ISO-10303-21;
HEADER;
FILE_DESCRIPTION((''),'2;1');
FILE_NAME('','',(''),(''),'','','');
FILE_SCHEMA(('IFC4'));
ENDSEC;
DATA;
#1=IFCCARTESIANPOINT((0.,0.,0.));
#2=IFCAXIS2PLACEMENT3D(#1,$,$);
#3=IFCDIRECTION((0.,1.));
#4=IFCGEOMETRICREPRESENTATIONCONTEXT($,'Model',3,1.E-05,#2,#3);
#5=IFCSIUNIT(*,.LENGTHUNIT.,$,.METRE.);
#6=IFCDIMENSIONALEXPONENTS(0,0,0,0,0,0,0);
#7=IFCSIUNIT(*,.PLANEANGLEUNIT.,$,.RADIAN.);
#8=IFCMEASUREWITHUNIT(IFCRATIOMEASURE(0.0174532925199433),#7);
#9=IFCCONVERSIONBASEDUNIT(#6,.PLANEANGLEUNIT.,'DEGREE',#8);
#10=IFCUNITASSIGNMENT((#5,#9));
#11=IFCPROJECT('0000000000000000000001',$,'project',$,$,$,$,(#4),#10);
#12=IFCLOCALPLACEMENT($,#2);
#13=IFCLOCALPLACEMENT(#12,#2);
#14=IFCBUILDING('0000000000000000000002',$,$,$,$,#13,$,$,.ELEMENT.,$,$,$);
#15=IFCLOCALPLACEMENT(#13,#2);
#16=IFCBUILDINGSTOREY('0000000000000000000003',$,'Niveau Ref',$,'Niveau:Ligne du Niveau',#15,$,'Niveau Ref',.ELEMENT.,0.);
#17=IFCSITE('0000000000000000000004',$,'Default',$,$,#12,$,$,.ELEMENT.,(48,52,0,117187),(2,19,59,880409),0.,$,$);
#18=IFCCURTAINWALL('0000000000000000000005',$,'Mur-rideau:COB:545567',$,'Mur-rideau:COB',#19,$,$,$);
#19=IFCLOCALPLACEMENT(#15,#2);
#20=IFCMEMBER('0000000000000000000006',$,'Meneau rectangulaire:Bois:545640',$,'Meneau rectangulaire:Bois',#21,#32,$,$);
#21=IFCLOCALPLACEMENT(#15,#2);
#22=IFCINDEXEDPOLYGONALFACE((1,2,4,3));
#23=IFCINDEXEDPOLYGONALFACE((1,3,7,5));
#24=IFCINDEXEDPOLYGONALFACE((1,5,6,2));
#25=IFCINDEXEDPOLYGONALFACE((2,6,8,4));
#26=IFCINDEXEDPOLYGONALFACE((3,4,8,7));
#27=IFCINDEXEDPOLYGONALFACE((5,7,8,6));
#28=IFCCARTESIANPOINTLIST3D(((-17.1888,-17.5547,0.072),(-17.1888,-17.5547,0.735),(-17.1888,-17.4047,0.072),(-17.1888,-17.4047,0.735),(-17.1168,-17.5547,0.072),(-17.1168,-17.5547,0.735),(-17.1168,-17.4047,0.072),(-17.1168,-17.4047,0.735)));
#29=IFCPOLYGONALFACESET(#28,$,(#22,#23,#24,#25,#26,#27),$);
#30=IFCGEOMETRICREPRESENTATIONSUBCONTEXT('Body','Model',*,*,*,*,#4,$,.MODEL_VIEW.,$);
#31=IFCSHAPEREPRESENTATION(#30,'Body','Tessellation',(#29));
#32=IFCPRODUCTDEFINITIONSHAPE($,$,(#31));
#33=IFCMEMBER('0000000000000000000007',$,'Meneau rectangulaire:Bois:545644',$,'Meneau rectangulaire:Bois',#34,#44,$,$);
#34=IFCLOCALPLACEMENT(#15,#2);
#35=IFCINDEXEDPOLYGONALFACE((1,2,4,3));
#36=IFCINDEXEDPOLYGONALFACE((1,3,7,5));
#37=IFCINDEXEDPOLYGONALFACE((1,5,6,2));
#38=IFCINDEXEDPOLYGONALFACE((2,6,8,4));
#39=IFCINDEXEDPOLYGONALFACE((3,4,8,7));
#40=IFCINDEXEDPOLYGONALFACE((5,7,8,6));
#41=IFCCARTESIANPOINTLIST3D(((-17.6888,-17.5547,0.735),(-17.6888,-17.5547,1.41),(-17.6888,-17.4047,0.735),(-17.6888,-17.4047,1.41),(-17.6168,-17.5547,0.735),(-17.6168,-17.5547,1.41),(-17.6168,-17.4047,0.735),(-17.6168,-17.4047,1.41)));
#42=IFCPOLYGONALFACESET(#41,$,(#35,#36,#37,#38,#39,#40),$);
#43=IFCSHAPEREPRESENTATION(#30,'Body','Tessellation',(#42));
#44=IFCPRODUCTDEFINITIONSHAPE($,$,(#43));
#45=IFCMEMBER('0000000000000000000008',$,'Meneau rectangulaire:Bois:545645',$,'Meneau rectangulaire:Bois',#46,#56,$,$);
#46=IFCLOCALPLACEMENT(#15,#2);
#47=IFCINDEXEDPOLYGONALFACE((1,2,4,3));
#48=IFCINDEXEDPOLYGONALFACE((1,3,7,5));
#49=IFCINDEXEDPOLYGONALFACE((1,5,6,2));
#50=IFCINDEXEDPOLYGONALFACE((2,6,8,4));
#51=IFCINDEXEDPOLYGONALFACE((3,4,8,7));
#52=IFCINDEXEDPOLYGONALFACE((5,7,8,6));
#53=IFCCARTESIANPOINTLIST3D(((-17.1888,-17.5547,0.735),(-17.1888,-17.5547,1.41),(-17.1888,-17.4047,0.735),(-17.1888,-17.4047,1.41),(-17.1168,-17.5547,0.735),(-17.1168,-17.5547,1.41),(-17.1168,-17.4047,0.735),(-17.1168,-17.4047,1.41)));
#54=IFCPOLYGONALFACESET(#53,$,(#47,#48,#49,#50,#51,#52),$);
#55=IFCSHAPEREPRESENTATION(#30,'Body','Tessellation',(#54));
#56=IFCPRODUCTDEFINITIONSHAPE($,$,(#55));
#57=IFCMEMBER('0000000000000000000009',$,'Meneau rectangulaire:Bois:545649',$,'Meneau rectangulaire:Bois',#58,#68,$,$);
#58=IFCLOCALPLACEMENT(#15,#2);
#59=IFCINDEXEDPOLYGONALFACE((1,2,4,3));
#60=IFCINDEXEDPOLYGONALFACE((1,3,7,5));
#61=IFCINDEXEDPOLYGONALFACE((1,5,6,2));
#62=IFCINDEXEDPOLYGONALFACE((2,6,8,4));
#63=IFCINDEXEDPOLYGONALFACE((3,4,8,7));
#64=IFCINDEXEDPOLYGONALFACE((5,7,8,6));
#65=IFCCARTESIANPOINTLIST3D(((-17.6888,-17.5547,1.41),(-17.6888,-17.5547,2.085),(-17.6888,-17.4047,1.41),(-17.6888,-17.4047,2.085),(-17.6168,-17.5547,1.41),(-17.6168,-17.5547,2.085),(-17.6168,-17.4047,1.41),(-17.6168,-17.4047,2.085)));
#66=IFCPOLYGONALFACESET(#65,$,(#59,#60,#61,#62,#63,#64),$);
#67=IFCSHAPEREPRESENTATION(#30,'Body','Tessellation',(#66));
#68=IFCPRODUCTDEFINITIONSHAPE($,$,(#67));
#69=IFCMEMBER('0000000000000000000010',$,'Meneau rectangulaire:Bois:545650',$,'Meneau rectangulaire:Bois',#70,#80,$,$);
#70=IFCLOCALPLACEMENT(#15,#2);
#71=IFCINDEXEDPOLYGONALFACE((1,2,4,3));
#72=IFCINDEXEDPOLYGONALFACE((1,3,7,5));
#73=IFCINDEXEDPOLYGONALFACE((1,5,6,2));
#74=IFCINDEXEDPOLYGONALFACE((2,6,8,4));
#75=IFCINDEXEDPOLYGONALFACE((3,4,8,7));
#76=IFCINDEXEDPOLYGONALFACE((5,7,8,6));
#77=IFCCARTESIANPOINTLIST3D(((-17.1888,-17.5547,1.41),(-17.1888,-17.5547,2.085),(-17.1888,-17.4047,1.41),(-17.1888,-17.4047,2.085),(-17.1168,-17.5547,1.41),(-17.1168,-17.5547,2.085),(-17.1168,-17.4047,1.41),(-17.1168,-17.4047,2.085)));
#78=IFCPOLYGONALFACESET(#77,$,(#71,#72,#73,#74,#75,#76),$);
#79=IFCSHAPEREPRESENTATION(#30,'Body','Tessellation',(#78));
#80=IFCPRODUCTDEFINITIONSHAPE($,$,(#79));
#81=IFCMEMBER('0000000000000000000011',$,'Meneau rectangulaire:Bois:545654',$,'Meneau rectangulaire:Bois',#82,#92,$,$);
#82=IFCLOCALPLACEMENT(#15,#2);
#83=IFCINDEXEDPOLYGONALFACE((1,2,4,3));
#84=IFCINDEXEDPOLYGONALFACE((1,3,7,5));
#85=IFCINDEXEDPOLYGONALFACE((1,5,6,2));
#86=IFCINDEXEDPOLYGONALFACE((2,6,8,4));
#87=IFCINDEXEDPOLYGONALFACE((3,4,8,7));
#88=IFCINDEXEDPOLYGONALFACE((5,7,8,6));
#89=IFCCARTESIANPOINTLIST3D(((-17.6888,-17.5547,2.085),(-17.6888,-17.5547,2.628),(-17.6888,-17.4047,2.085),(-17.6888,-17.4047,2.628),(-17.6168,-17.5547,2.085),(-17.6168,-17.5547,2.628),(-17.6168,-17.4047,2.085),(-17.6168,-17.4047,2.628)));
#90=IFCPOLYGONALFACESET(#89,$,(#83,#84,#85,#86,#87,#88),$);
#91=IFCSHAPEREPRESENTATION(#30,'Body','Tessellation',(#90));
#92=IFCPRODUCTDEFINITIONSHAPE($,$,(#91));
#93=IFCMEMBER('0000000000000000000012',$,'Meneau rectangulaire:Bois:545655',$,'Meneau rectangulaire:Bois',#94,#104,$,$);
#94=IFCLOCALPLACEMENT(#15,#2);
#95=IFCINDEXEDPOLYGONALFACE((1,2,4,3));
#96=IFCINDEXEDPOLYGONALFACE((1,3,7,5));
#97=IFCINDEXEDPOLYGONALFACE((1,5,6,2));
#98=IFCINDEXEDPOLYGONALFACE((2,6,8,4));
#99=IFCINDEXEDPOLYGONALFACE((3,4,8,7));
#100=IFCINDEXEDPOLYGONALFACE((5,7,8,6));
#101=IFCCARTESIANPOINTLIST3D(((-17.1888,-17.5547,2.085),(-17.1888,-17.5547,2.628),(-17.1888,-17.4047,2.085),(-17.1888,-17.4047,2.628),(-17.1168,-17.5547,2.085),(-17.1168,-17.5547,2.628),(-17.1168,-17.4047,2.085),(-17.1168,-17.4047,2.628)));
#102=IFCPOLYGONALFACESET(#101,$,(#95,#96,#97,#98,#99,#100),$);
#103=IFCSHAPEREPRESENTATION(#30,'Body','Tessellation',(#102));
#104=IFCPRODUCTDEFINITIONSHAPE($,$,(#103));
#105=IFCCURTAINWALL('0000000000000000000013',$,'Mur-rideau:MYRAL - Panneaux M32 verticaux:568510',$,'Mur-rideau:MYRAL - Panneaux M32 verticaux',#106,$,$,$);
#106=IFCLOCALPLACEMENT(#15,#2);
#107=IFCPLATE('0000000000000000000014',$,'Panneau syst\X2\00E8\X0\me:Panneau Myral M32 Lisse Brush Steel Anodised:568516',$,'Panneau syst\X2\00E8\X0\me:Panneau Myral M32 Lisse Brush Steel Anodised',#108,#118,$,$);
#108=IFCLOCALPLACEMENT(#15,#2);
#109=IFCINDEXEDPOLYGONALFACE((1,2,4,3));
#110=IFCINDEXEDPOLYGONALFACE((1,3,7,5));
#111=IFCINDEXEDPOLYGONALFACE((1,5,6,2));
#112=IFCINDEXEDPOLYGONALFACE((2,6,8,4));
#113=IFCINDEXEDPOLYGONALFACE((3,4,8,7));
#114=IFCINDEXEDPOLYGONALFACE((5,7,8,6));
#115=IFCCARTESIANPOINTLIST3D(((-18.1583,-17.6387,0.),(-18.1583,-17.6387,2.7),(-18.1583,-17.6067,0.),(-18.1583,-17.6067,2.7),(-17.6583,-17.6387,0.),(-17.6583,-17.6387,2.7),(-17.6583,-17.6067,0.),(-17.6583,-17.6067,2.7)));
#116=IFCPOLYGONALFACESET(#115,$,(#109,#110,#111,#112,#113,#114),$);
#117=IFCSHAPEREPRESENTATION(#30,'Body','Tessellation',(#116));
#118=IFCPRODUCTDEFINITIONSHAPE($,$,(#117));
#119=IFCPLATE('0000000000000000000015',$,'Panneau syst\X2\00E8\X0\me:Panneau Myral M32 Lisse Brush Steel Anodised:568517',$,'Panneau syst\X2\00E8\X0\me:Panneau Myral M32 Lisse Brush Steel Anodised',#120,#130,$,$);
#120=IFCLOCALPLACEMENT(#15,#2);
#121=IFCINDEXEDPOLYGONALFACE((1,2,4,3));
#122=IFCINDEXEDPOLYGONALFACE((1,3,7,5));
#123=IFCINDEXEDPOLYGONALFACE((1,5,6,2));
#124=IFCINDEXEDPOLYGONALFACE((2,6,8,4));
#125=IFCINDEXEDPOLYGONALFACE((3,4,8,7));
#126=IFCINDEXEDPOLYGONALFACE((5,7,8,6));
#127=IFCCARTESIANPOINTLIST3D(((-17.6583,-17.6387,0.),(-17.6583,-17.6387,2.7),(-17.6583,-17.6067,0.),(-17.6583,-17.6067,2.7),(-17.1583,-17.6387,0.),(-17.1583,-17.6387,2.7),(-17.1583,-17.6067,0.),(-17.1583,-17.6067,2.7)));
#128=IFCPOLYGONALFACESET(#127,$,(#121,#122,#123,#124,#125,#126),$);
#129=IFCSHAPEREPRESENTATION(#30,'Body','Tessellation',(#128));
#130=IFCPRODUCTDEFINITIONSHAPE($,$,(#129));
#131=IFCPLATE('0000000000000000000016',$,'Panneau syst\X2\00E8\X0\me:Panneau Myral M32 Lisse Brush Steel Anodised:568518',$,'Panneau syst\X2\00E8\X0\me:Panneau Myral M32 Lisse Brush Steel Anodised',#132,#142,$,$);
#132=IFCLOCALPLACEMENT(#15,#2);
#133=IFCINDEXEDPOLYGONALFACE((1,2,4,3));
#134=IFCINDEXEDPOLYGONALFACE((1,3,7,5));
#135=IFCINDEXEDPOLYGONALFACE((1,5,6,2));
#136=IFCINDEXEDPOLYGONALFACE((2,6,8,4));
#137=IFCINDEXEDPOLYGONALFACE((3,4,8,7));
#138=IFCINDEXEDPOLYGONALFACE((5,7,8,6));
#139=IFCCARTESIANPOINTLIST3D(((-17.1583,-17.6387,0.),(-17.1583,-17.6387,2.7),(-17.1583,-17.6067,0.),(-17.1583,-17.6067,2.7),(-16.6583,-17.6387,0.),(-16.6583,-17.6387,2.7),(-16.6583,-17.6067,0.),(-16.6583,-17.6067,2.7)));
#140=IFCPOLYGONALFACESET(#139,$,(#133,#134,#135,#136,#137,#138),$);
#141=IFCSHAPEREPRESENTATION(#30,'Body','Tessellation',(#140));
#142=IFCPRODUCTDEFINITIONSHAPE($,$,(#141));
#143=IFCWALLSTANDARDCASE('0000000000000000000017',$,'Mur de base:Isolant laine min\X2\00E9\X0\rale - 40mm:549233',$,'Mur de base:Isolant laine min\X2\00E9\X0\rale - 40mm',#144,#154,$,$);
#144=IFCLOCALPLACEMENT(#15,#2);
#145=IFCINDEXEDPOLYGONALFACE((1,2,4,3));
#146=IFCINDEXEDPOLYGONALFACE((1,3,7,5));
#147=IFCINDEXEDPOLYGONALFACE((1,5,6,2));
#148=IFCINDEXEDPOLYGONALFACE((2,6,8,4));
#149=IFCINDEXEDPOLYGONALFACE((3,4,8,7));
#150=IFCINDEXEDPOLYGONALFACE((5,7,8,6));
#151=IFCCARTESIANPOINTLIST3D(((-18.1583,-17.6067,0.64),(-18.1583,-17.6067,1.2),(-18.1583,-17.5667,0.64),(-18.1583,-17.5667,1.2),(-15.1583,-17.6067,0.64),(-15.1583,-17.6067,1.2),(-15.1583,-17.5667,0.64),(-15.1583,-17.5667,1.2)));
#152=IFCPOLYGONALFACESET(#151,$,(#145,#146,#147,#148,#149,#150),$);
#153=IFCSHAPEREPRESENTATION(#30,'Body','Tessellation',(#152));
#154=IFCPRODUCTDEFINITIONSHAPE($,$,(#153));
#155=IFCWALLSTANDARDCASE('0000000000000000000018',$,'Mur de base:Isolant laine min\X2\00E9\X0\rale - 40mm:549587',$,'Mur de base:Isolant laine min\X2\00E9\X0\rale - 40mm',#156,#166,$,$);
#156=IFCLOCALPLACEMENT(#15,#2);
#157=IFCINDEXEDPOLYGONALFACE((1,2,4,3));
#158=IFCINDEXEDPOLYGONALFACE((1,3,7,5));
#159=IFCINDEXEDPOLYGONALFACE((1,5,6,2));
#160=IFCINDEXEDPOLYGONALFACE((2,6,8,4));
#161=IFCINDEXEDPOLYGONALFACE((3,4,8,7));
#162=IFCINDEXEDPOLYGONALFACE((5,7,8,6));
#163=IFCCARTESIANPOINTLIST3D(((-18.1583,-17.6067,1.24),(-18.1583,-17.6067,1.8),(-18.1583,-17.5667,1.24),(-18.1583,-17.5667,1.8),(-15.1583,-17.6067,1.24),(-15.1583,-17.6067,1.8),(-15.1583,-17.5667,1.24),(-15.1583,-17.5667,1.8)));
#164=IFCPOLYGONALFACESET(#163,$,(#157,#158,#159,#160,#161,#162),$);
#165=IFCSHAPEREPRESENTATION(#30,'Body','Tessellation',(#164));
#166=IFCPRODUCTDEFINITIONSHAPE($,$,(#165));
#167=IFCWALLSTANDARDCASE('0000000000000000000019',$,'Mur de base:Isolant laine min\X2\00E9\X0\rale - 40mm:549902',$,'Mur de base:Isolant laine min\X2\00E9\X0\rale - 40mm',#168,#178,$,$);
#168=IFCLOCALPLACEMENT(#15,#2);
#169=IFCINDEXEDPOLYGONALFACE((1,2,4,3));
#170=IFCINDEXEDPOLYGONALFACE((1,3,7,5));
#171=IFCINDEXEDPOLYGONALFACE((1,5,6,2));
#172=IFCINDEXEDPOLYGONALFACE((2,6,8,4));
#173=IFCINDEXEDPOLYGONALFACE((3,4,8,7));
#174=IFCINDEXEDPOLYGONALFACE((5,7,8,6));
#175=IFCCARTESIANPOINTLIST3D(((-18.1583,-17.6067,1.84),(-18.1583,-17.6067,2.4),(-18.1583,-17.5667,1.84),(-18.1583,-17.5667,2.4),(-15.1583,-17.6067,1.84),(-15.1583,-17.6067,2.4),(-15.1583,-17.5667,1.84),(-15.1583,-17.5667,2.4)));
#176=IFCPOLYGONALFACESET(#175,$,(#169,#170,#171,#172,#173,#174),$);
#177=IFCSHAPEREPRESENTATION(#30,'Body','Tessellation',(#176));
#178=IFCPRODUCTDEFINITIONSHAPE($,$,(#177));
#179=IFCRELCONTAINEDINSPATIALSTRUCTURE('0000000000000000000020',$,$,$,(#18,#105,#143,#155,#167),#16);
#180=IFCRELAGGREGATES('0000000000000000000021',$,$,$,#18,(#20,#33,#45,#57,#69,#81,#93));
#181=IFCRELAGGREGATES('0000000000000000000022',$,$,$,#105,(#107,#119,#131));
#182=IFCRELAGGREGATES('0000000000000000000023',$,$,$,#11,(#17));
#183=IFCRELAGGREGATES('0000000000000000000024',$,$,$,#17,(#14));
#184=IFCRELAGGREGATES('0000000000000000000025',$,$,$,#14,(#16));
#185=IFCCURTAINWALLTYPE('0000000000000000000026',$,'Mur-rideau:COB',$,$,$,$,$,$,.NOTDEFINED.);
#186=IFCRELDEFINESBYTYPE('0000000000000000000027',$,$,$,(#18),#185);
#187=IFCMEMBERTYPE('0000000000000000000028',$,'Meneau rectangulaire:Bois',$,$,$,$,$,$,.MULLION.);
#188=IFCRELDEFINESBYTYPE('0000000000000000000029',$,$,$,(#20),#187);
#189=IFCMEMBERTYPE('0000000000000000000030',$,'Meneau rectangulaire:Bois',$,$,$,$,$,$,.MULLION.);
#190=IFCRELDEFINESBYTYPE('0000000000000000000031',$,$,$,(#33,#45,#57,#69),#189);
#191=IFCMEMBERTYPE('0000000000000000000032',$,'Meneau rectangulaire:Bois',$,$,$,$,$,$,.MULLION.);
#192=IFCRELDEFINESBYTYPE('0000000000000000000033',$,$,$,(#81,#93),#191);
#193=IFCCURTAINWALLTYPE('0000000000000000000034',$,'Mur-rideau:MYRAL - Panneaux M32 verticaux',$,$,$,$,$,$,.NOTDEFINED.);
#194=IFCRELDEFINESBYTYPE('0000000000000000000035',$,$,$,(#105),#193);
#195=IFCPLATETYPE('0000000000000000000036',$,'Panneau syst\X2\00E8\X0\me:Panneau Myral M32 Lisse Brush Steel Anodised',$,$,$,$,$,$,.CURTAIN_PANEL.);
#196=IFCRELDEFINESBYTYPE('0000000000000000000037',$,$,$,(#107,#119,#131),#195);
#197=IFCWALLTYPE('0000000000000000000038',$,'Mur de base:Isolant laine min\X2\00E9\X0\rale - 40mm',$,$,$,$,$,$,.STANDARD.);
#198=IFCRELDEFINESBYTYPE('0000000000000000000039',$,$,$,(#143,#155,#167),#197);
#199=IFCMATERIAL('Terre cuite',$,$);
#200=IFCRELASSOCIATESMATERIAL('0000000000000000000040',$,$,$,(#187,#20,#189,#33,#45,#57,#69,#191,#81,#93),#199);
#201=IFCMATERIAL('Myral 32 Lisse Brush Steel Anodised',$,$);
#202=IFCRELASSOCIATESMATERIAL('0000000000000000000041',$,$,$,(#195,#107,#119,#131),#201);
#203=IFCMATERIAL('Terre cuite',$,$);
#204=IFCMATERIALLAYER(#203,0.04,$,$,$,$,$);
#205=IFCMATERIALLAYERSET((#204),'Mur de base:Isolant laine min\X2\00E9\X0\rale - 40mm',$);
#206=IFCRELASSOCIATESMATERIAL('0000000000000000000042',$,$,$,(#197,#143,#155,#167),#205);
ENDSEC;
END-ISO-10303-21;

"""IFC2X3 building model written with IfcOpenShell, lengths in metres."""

from ifc_helpers import new_model, entity, si_unit, converted_unit, direction, frame, frame_2d, origin, origin_2d_with_axis, place, context, subcontext, project, spatial, rectangle, extrude, source, transform, mapped, material, layer, layer_set, layer_usage, type_object, type_shapes, element, aggregate, save


model = new_model("IFC2X3")

# Units and contexts
model_context = context("Model", 3, precision=1e-05, world=origin(), true_north=direction((0.0, 1.0)))
body_context = subcontext(model_context, "Body", "Model", "MODEL_VIEW")
ifc_project = project(units=[si_unit("LENGTHUNIT", "METRE"), converted_unit("PLANEANGLEUNIT", "DEGREE", entity("IfcRatioMeasure", 0.0174532925199433), si_unit("PLANEANGLEUNIT", "RADIAN"), dimensions=[0, 0, 0, 0, 0, 0, 0])], contexts=[model_context])

# Site, building, storey
site_placement = place(None, origin())
site = spatial("IfcSite", under=ifc_project, at=site_placement, Name="Default", CompositionType="ELEMENT", RefLatitude=(48, 52, 0, 117187), RefLongitude=(2, 19, 59, 880409), RefElevation=0.0)
building_placement = place(site_placement, origin())
building = spatial("IfcBuilding", under=site, at=building_placement, CompositionType="ELEMENT")
storey_placement = place(building_placement, origin())
storey = spatial("IfcBuildingStorey", under=building, at=storey_placement, Name="Niveau Ref", ObjectType="Niveau:Ligne du Niveau", LongName="Niveau Ref", CompositionType="ELEMENT", Elevation=0.0)

# Curtain wall, members
curtain_wall_type_1 = type_object("IfcCurtainWallType", Name="Mur-rideau:COB", PredefinedType="NOTDEFINED")
curtain_wall_1_placement = place(storey_placement, origin())
curtain_wall_1 = element("IfcCurtainWall", 1, at=curtain_wall_1_placement, inside=storey, type_object=curtain_wall_type_1, Name="Mur-rideau:COB:545567", ObjectType="Mur-rideau:COB")
ifc_material_1 = material(Name="Terre cuite")
member_type_1 = type_object("IfcMemberType", Name="Meneau rectangulaire:Bois", PredefinedType="MULLION", material=ifc_material_1)
shared_shape_1 = source(origin(), body_context, "Body", "SweptSolid", [
    extrude(rectangle(XDim=0.15, YDim=0.072, at=origin_2d_with_axis()), frame((-0.024, 0.0, -0.663), z_axis=(0.0, 0.0, 1.0), x_axis=(0.0, -1.0, 0.0)), (0.0, 0.0, 1.0), 0.663),
])
type_shapes(member_type_1, [shared_shape_1])
member_1_placement = place(storey_placement, frame((-17.1288, -17.4797, 0.072), z_axis=(0.0, 0.0, -1.0), x_axis=(1.0, 0.0, 0.0)))
member_1 = element("IfcMember", 2, at=member_1_placement, type_object=member_type_1, material=ifc_material_1, Name="Meneau rectangulaire:Bois:545640", ObjectType="Meneau rectangulaire:Bois", context=body_context, shape_type="MappedRepresentation", body=[
    mapped(shared_shape_1, transform((0.0, 0.0, 0.0), scale=1.0)),
])
member_type_2 = type_object("IfcMemberType", Name="Meneau rectangulaire:Bois", PredefinedType="MULLION", material=ifc_material_1)
shared_shape_2 = source(origin(), body_context, "Body", "SweptSolid", [
    extrude(rectangle(XDim=0.15, YDim=0.072, at=origin_2d_with_axis()), frame((-0.024, 0.0, -0.675), z_axis=(0.0, 0.0, 1.0), x_axis=(0.0, -1.0, 0.0)), (0.0, 0.0, 1.0), 0.675),
])
type_shapes(member_type_2, [shared_shape_2])
member_2_placement = place(storey_placement, frame((-17.6288, -17.4797, 0.735), z_axis=(0.0, 0.0, -1.0), x_axis=(1.0, 0.0, 0.0)))
member_2 = element("IfcMember", 3, at=member_2_placement, type_object=member_type_2, material=ifc_material_1, Name="Meneau rectangulaire:Bois:545644", ObjectType="Meneau rectangulaire:Bois", context=body_context, shape_type="MappedRepresentation", body=[
    mapped(shared_shape_2, transform((0.0, 0.0, 0.0), scale=1.0)),
])
member_3_placement = place(storey_placement, frame((-17.1288, -17.4797, 0.735), z_axis=(0.0, 0.0, -1.0), x_axis=(1.0, 0.0, 0.0)))
member_3 = element("IfcMember", 4, at=member_3_placement, type_object=member_type_2, material=ifc_material_1, Name="Meneau rectangulaire:Bois:545645", ObjectType="Meneau rectangulaire:Bois", context=body_context, shape_type="MappedRepresentation", body=[
    mapped(shared_shape_2, transform((0.0, 0.0, 0.0), scale=1.0)),
])
member_4_placement = place(storey_placement, frame((-17.6288, -17.4797, 1.41), z_axis=(0.0, 0.0, -1.0), x_axis=(1.0, 0.0, 0.0)))
member_4 = element("IfcMember", 5, at=member_4_placement, type_object=member_type_2, material=ifc_material_1, Name="Meneau rectangulaire:Bois:545649", ObjectType="Meneau rectangulaire:Bois", context=body_context, shape_type="MappedRepresentation", body=[
    mapped(shared_shape_2, transform((0.0, 0.0, 0.0), scale=1.0)),
])
member_5_placement = place(storey_placement, frame((-17.1288, -17.4797, 1.41), z_axis=(0.0, 0.0, -1.0), x_axis=(1.0, 0.0, 0.0)))
member_5 = element("IfcMember", 6, at=member_5_placement, type_object=member_type_2, material=ifc_material_1, Name="Meneau rectangulaire:Bois:545650", ObjectType="Meneau rectangulaire:Bois", context=body_context, shape_type="MappedRepresentation", body=[
    mapped(shared_shape_2, transform((0.0, 0.0, 0.0), scale=1.0)),
])
member_type_3 = type_object("IfcMemberType", Name="Meneau rectangulaire:Bois", PredefinedType="MULLION", material=ifc_material_1)
shared_shape_3 = source(origin(), body_context, "Body", "SweptSolid", [
    extrude(rectangle(XDim=0.15, YDim=0.072, at=origin_2d_with_axis()), frame((-0.024, 0.0, -0.543), z_axis=(0.0, 0.0, 1.0), x_axis=(0.0, -1.0, 0.0)), (0.0, 0.0, 1.0), 0.543),
])
type_shapes(member_type_3, [shared_shape_3])
member_6_placement = place(storey_placement, frame((-17.6288, -17.4797, 2.085), z_axis=(0.0, 0.0, -1.0), x_axis=(1.0, 0.0, 0.0)))
member_6 = element("IfcMember", 7, at=member_6_placement, type_object=member_type_3, material=ifc_material_1, Name="Meneau rectangulaire:Bois:545654", ObjectType="Meneau rectangulaire:Bois", context=body_context, shape_type="MappedRepresentation", body=[
    mapped(shared_shape_3, transform((0.0, 0.0, 0.0), scale=1.0)),
])
member_7_placement = place(storey_placement, frame((-17.1288, -17.4797, 2.085), z_axis=(0.0, 0.0, -1.0), x_axis=(1.0, 0.0, 0.0)))
member_7 = element("IfcMember", 8, at=member_7_placement, type_object=member_type_3, material=ifc_material_1, Name="Meneau rectangulaire:Bois:545655", ObjectType="Meneau rectangulaire:Bois", context=body_context, shape_type="MappedRepresentation", body=[
    mapped(shared_shape_3, transform((0.0, 0.0, 0.0), scale=1.0)),
])
aggregate(curtain_wall_1, [member_1, member_2, member_3, member_4, member_5, member_6, member_7])

# Curtain wall, plates
curtain_wall_type_2 = type_object("IfcCurtainWallType", Name="Mur-rideau:MYRAL - Panneaux M32 verticaux", PredefinedType="NOTDEFINED")
curtain_wall_2_placement = place(storey_placement, origin())
curtain_wall_2 = element("IfcCurtainWall", 9, at=curtain_wall_2_placement, inside=storey, type_object=curtain_wall_type_2, Name="Mur-rideau:MYRAL - Panneaux M32 verticaux:568510", ObjectType="Mur-rideau:MYRAL - Panneaux M32 verticaux")
ifc_material_2 = material(Name="Myral 32 Lisse Brush Steel Anodised")
plate_type = type_object("IfcPlateType", Name="Panneau système:Panneau Myral M32 Lisse Brush Steel Anodised", PredefinedType="CURTAIN_PANEL", material=ifc_material_2)
shared_shape_4 = source(origin(), body_context, "Body", "SweptSolid", [
    extrude(rectangle(XDim=0.032, YDim=0.5, at=origin_2d_with_axis()), frame((0.0, -0.016, 0.0), z_axis=(0.0, 0.0, 1.0), x_axis=(0.0, 1.0, 0.0)), (0.0, 0.0, 1.0), 2.7),
])
type_shapes(plate_type, [shared_shape_4])
plate_1_placement = place(curtain_wall_2_placement, frame((-17.9083, -17.6067, 0.0)))
plate_1 = element("IfcPlate", 10, at=plate_1_placement, type_object=plate_type, material=ifc_material_2, Name="Panneau système:Panneau Myral M32 Lisse Brush Steel Anodised:568516", ObjectType="Panneau système:Panneau Myral M32 Lisse Brush Steel Anodised", context=body_context, shape_type="MappedRepresentation", body=[
    mapped(shared_shape_4, transform((0.0, 0.0, 0.0), scale=1.0)),
])
plate_2_placement = place(curtain_wall_2_placement, frame((-17.4083, -17.6067, 0.0)))
plate_2 = element("IfcPlate", 11, at=plate_2_placement, type_object=plate_type, material=ifc_material_2, Name="Panneau système:Panneau Myral M32 Lisse Brush Steel Anodised:568517", ObjectType="Panneau système:Panneau Myral M32 Lisse Brush Steel Anodised", context=body_context, shape_type="MappedRepresentation", body=[
    mapped(shared_shape_4, transform((0.0, 0.0, 0.0), scale=1.0)),
])
plate_3_placement = place(curtain_wall_2_placement, frame((-16.9083, -17.6067, 0.0)))
plate_3 = element("IfcPlate", 12, at=plate_3_placement, type_object=plate_type, material=ifc_material_2, Name="Panneau système:Panneau Myral M32 Lisse Brush Steel Anodised:568518", ObjectType="Panneau système:Panneau Myral M32 Lisse Brush Steel Anodised", context=body_context, shape_type="MappedRepresentation", body=[
    mapped(shared_shape_4, transform((0.0, 0.0, 0.0), scale=1.0)),
])
aggregate(curtain_wall_2, [plate_1, plate_2, plate_3])

# Walls
ifc_material_3 = material(Name="Terre cuite")
ifc_layer = layer(ifc_material_3, 0.04)
ifc_layer_set = layer_set([ifc_layer], Name="Mur de base:Isolant laine minérale - 40mm")
ifc_layer_usage_1 = layer_usage(ifc_layer_set, "AXIS2", "NEGATIVE", 0.02)
wall_type = type_object("IfcWallType", Name="Mur de base:Isolant laine minérale - 40mm", PredefinedType="STANDARD", material=ifc_layer_set)
wall_1_placement = place(storey_placement, frame((-18.1583, -17.5867, 0.64)))
element("IfcWallStandardCase", 13, at=wall_1_placement, inside=storey, type_object=wall_type, material=ifc_layer_usage_1, Name="Mur de base:Isolant laine minérale - 40mm:549233", ObjectType="Mur de base:Isolant laine minérale - 40mm", context=body_context, shape_type="SweptSolid", body=[
    extrude(rectangle(XDim=3.0, YDim=0.04, at=frame_2d((1.5, 0.0), x_axis=(-1.0, 0.0))), origin(), (0.0, 0.0, 1.0), 0.56),
])
ifc_layer_usage_2 = layer_usage(ifc_layer_set, "AXIS2", "NEGATIVE", 0.02)
wall_2_placement = place(storey_placement, frame((-18.1583, -17.5867, 1.24)))
element("IfcWallStandardCase", 14, at=wall_2_placement, inside=storey, type_object=wall_type, material=ifc_layer_usage_2, Name="Mur de base:Isolant laine minérale - 40mm:549587", ObjectType="Mur de base:Isolant laine minérale - 40mm", context=body_context, shape_type="SweptSolid", body=[
    extrude(rectangle(XDim=3.0, YDim=0.04, at=frame_2d((1.5, 0.0), x_axis=(-1.0, 0.0))), origin(), (0.0, 0.0, 1.0), 0.56),
])
ifc_layer_usage_3 = layer_usage(ifc_layer_set, "AXIS2", "NEGATIVE", 0.02)
wall_3_placement = place(storey_placement, frame((-18.1583, -17.5867, 1.84)))
element("IfcWallStandardCase", 15, at=wall_3_placement, inside=storey, type_object=wall_type, material=ifc_layer_usage_3, Name="Mur de base:Isolant laine minérale - 40mm:549902", ObjectType="Mur de base:Isolant laine minérale - 40mm", context=body_context, shape_type="SweptSolid", body=[
    extrude(rectangle(XDim=3.0, YDim=0.04, at=frame_2d((1.5, 0.0), x_axis=(-1.0, 0.0))), origin(), (0.0, 0.0, 1.0), 0.56),
])

save(model, "model.ifc")
